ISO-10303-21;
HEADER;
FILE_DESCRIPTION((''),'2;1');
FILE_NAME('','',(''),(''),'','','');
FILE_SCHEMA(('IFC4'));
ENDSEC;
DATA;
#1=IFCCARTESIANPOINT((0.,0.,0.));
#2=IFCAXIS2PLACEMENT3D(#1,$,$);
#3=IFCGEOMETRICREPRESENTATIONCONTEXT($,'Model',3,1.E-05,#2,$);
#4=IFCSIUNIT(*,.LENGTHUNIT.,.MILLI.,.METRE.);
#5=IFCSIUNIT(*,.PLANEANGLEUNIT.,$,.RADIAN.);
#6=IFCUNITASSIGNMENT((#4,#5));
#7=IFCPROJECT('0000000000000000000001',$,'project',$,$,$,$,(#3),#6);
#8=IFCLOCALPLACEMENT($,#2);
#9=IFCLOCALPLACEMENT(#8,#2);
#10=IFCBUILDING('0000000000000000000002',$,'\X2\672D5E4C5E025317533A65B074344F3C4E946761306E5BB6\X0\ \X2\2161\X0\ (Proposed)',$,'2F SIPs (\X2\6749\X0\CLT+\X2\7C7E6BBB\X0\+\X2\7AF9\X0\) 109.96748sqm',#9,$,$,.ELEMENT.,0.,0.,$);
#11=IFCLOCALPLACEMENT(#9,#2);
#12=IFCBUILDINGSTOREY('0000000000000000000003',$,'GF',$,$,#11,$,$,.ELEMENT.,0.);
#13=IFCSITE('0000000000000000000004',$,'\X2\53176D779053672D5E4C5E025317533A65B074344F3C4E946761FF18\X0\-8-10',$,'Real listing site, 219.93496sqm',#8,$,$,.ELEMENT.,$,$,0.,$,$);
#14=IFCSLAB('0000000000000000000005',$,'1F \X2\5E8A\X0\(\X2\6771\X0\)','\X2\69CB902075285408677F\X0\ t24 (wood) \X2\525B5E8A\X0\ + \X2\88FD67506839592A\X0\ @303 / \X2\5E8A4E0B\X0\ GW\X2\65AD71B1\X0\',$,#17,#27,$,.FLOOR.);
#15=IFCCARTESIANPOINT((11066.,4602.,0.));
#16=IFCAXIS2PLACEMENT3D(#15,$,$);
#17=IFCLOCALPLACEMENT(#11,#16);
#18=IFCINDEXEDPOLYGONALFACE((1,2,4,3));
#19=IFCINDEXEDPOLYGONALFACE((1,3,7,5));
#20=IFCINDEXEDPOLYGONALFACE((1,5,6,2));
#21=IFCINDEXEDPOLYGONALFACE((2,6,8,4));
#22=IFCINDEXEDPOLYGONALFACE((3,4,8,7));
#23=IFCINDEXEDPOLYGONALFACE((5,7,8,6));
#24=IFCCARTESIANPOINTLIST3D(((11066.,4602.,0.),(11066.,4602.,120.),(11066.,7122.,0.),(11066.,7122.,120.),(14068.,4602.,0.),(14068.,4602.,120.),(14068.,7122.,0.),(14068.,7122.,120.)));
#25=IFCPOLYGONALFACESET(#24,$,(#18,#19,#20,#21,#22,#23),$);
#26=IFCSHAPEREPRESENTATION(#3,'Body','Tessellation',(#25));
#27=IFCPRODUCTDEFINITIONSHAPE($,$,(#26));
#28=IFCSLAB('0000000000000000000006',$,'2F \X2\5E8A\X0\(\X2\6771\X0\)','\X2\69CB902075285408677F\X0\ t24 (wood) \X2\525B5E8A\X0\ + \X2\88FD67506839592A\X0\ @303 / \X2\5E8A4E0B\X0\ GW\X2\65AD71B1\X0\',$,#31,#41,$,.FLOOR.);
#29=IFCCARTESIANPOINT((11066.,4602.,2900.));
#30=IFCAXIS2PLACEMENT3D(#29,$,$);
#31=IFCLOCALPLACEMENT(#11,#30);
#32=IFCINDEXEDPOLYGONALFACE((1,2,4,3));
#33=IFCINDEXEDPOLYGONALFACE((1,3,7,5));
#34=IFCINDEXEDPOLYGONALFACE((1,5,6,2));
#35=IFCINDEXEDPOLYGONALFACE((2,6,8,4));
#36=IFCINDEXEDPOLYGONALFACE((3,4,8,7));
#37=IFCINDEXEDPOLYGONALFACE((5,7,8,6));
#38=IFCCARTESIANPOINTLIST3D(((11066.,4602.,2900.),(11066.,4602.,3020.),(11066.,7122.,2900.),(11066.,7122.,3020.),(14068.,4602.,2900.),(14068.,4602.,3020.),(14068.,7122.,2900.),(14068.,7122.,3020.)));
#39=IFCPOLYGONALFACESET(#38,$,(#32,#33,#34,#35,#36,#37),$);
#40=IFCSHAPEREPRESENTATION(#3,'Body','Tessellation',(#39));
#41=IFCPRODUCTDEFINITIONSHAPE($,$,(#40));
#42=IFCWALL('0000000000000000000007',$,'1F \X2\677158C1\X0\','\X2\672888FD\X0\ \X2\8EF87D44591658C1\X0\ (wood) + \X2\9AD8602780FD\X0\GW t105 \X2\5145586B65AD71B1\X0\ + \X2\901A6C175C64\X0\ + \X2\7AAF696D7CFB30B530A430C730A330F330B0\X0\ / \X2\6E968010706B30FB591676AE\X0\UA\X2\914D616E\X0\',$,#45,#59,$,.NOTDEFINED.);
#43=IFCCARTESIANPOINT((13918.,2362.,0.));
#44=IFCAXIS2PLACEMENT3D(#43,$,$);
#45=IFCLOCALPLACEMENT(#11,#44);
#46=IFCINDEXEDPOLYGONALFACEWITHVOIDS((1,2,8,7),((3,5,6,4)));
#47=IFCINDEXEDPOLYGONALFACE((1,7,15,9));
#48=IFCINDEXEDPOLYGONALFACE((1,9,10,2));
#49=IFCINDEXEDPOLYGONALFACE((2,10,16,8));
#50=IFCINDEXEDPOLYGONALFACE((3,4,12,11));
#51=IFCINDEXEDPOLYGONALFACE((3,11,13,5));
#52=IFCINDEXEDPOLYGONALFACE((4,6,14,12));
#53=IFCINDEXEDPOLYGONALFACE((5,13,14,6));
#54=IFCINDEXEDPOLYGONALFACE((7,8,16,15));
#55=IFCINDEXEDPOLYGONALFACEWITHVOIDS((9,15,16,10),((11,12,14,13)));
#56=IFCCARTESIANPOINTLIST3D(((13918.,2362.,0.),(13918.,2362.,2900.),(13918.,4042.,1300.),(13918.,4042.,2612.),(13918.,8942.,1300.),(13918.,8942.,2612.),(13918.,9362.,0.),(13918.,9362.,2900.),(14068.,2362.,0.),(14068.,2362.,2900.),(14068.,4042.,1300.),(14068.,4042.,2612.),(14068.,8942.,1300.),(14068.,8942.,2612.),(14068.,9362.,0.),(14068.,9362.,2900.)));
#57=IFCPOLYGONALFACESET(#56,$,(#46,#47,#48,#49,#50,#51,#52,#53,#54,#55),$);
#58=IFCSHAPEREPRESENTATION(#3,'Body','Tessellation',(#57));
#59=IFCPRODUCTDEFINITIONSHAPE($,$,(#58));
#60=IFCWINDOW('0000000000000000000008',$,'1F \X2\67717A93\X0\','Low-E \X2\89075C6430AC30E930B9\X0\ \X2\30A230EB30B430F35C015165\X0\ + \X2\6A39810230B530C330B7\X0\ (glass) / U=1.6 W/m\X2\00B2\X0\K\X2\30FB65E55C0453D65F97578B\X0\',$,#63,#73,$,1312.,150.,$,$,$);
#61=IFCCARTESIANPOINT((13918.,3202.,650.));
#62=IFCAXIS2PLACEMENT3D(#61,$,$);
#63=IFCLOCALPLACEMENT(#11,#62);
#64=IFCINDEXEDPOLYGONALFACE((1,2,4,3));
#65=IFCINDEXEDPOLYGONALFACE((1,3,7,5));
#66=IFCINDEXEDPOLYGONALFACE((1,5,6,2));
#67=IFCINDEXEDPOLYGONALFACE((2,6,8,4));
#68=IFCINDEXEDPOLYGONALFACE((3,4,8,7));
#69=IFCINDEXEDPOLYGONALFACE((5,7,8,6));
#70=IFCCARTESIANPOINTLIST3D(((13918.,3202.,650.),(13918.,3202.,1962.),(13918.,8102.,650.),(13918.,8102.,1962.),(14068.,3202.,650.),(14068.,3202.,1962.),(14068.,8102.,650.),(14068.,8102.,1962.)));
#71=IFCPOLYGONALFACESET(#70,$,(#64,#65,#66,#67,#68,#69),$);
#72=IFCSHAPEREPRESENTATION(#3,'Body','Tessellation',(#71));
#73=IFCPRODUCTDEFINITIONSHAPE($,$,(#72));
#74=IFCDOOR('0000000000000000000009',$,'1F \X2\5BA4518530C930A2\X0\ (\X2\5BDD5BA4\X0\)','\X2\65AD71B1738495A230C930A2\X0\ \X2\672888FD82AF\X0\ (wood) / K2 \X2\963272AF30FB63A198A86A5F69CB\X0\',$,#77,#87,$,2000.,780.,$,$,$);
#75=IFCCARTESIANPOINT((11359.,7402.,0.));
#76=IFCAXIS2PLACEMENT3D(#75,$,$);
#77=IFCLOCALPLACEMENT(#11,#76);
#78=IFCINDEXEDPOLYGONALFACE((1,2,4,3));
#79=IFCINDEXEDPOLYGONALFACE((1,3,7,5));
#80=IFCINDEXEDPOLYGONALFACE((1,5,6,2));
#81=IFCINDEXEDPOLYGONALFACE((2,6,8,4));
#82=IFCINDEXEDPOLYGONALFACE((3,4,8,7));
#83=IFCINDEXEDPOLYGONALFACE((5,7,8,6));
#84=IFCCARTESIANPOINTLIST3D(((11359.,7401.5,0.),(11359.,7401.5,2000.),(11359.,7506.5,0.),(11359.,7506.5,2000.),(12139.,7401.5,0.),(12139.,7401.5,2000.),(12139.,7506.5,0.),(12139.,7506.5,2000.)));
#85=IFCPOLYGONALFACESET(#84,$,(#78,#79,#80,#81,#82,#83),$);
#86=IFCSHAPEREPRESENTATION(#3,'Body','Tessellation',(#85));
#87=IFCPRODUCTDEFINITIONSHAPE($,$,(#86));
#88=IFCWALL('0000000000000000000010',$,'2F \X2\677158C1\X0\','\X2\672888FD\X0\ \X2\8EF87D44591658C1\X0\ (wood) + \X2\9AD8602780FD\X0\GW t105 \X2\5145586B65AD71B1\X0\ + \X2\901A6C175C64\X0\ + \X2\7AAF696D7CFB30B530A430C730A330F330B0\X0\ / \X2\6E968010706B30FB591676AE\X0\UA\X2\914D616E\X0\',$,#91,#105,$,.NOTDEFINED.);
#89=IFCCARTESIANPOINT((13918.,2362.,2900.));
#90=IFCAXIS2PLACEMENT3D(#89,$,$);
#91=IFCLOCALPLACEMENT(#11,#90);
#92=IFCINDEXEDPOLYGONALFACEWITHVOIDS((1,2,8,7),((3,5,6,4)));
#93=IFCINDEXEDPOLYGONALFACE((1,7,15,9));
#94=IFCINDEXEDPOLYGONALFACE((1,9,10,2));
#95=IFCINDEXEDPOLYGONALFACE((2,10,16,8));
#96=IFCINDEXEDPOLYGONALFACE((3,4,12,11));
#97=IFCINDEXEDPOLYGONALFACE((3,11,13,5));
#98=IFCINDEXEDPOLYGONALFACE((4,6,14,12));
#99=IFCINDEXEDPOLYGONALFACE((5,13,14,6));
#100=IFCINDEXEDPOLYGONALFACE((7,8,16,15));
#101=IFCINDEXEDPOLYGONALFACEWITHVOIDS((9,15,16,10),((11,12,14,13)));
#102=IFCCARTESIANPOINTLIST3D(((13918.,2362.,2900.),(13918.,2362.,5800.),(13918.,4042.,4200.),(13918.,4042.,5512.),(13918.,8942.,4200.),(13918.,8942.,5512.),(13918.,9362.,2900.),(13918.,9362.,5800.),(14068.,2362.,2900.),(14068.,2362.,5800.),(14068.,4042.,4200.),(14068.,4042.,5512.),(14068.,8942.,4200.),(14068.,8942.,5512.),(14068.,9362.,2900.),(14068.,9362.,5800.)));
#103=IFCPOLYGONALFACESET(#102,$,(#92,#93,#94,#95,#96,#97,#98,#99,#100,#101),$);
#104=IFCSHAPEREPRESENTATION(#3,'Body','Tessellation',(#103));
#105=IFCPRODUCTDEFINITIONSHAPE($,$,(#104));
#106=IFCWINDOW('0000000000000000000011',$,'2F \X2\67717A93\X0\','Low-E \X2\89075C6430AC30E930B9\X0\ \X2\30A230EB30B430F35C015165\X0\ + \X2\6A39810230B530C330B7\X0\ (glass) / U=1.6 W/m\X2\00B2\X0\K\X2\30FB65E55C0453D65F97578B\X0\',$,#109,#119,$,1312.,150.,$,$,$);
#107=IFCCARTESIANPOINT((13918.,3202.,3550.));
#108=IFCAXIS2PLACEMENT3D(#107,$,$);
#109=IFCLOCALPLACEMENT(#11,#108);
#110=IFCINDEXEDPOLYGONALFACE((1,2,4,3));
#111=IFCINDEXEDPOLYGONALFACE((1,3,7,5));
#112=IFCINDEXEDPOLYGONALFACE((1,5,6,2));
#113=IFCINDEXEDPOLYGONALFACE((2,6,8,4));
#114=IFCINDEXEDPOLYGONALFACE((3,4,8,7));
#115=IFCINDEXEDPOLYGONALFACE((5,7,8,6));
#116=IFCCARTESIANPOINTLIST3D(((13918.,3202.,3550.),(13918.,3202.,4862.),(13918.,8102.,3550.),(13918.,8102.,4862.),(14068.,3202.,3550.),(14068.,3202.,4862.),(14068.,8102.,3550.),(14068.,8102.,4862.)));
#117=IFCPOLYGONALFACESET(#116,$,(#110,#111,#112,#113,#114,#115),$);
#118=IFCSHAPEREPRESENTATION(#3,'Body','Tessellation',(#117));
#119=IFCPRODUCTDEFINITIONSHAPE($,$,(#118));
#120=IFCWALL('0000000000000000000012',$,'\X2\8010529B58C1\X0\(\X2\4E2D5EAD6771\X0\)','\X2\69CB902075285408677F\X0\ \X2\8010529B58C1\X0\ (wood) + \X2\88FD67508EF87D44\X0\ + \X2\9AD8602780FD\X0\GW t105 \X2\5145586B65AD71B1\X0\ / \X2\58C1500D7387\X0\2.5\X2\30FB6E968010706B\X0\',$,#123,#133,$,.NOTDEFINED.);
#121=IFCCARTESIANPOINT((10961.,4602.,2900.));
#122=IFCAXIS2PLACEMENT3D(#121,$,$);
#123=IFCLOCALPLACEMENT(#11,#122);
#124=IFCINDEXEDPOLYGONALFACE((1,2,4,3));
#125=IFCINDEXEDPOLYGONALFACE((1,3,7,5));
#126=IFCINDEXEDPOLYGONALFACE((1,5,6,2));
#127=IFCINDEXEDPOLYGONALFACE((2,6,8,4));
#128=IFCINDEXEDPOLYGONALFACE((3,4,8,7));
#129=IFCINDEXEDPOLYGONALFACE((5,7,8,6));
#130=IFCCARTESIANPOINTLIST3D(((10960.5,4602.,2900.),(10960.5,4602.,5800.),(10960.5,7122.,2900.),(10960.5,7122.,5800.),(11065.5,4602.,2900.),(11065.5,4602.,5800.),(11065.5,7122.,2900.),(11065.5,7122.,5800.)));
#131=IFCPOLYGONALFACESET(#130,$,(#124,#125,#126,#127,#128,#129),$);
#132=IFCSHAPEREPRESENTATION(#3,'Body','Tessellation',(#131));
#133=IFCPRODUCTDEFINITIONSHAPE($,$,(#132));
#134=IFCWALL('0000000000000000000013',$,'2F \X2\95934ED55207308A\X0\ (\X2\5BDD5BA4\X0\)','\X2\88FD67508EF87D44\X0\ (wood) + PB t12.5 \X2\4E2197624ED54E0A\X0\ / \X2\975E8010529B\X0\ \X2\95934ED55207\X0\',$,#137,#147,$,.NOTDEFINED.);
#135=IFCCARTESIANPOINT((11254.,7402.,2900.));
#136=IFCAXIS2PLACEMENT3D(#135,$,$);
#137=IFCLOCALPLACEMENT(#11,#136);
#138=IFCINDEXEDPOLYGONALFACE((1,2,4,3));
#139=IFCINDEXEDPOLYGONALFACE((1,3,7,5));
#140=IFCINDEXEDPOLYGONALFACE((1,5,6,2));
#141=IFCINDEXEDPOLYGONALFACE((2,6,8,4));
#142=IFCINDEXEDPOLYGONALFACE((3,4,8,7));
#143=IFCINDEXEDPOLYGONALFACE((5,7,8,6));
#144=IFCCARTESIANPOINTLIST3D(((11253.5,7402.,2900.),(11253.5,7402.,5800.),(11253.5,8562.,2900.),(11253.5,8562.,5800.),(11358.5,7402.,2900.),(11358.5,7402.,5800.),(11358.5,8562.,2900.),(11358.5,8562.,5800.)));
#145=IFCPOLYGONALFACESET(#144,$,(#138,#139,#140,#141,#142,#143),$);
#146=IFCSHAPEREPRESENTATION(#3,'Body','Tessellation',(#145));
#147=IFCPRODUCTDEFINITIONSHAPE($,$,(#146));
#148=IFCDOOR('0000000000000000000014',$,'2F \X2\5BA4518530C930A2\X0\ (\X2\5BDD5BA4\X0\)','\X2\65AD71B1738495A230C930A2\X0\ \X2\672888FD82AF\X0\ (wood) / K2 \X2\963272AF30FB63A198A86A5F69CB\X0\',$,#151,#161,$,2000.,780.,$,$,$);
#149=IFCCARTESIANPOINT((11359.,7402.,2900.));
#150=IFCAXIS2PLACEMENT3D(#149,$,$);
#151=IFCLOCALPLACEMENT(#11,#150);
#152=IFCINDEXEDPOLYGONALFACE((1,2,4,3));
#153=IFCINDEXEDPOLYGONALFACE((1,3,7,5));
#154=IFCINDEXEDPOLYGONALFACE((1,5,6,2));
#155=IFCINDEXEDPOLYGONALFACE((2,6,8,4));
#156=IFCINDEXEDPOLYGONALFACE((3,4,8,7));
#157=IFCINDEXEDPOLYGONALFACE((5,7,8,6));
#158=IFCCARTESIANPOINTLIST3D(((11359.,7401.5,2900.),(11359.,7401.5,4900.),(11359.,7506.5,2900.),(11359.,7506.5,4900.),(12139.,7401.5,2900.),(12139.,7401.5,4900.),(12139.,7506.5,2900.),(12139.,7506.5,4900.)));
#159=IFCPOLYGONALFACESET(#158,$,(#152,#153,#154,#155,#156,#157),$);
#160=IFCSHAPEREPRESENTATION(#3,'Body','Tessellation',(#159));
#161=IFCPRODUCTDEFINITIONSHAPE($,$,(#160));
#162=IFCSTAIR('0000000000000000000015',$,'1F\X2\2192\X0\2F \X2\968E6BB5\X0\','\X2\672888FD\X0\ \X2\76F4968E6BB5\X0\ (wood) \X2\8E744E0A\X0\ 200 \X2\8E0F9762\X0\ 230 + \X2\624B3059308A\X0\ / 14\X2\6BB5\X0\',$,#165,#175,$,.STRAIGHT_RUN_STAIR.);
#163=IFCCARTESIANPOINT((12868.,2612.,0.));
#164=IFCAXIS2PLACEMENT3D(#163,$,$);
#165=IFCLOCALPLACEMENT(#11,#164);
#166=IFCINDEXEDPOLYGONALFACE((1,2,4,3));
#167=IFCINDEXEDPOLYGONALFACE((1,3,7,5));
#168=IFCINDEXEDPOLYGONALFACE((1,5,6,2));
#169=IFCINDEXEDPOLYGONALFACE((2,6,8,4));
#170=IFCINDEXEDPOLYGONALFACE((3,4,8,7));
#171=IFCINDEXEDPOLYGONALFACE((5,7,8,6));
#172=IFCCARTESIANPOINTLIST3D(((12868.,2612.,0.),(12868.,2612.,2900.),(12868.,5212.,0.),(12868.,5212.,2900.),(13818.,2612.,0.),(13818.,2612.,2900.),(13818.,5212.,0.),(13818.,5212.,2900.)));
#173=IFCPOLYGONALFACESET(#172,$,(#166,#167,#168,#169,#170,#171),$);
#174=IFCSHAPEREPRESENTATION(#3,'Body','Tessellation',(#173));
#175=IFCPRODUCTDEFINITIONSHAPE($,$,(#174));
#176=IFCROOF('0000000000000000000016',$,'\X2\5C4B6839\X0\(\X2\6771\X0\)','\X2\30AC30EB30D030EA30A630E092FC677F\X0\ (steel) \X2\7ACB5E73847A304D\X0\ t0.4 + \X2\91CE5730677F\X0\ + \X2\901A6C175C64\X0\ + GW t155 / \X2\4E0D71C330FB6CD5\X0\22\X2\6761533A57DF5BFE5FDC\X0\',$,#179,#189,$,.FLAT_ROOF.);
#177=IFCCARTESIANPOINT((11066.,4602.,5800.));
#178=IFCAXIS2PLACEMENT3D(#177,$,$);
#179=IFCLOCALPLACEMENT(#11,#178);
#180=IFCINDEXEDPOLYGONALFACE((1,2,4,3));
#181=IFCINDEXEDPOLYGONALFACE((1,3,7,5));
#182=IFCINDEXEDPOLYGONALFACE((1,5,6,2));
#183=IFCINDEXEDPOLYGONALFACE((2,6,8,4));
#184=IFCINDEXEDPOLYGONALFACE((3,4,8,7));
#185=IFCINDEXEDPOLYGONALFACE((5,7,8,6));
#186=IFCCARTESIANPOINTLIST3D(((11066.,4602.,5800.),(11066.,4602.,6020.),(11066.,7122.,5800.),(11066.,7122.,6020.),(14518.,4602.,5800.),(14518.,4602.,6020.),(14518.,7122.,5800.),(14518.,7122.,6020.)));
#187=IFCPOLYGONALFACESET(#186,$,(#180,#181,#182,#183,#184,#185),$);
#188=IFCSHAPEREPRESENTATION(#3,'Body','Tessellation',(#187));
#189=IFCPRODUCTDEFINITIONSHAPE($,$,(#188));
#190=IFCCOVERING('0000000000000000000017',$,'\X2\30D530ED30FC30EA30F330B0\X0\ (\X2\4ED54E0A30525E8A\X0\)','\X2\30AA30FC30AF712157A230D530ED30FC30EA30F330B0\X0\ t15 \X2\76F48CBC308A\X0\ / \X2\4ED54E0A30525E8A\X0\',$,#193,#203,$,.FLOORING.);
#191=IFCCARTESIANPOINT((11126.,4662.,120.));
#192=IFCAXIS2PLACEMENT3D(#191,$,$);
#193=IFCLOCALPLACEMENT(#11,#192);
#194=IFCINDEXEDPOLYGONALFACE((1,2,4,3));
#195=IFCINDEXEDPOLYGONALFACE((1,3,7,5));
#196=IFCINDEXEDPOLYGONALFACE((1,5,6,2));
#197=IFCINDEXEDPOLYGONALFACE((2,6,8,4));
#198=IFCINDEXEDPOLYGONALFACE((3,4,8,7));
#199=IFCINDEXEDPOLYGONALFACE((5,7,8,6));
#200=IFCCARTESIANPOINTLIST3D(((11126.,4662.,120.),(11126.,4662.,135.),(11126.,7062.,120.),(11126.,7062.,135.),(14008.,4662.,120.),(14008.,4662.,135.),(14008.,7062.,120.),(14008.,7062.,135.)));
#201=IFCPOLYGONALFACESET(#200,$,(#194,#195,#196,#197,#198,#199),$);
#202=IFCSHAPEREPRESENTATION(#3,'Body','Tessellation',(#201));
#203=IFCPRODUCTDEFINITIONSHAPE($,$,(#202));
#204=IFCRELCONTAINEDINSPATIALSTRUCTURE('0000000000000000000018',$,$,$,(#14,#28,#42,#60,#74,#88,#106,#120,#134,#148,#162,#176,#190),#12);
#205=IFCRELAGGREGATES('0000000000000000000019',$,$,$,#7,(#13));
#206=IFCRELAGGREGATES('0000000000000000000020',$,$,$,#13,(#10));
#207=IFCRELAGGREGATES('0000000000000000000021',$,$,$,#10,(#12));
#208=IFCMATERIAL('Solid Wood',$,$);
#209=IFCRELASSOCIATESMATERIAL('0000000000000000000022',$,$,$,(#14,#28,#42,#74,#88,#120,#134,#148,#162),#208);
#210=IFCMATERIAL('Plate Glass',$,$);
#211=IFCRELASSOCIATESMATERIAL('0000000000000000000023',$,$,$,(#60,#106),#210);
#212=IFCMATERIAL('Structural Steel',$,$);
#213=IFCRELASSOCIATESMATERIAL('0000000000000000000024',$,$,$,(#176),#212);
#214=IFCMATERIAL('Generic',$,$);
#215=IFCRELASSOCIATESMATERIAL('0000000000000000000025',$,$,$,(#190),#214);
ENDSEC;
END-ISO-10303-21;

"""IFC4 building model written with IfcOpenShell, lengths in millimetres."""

from ifc_helpers import new_model, si_unit, frame, frame_2d, origin, place, context, project, spatial, rectangle, extrude, material, element, fill, save


model = new_model("IFC4")

# Units and contexts
model_context = context("Model", 3, precision=1e-05, world=origin())
ifc_project = project(units=[si_unit("LENGTHUNIT", "METRE", prefix="MILLI"), si_unit("PLANEANGLEUNIT", "RADIAN")], contexts=[model_context])

# Site, building, storey
site_placement = place(None, origin())
site = spatial("IfcSite", under=ifc_project, at=site_placement, Name="北海道札幌市北区新琴似五条８-8-10", ObjectType="Real listing site, 219.93496sqm", CompositionType="ELEMENT", RefElevation=0.0)
building_placement = place(site_placement, origin())
building = spatial("IfcBuilding", under=site, at=building_placement, Name="札幌市北区新琴似五条の家 Ⅱ (Proposed)", ObjectType="2F SIPs (杉CLT+籾殻+竹) 109.96748sqm", CompositionType="ELEMENT", ElevationOfRefHeight=0.0, ElevationOfTerrain=0.0)
storey_placement = place(building_placement, origin())
storey = spatial("IfcBuildingStorey", under=building, at=storey_placement, Name="GF", CompositionType="ELEMENT", Elevation=0.0)

# Slabs
ifc_material_1 = material(Name="Solid Wood")
slab_1_placement = place(storey_placement, frame((11066.0, 4602.0, 0.0)))
element("IfcSlab", 1, at=slab_1_placement, inside=storey, material=ifc_material_1, Name="1F 床(東)", Description="構造用合板 t24 (wood) 剛床 + 製材根太 @303 / 床下 GW断熱", PredefinedType="FLOOR", context=model_context, shape_type="SweptSolid", body=[
    extrude(rectangle(XDim=3002.0, YDim=2520.0, at=frame_2d((1501.0, 1260.0))), frame((11066.0, 4602.0, 0.0)), (0.0, 0.0, 1.0), 120.0),
])
slab_2_placement = place(storey_placement, frame((11066.0, 4602.0, 2900.0)))
element("IfcSlab", 2, at=slab_2_placement, inside=storey, material=ifc_material_1, Name="2F 床(東)", Description="構造用合板 t24 (wood) 剛床 + 製材根太 @303 / 床下 GW断熱", PredefinedType="FLOOR", context=model_context, shape_type="SweptSolid", body=[
    extrude(rectangle(XDim=3002.0, YDim=2520.0, at=frame_2d((1501.0, 1260.0))), frame((11066.0, 4602.0, 2900.0)), (0.0, 0.0, 1.0), 120.0),
])

# Wall, opening, window
wall_1_placement = place(storey_placement, frame((13918.0, 2362.0, 0.0)))
wall_1 = element("IfcWall", 3, at=wall_1_placement, inside=storey, material=ifc_material_1, Name="1F 東壁", Description="木製 軸組外壁 (wood) + 高性能GW t105 充填断熱 + 通気層 + 窯業系サイディング / 準耐火・外皮UA配慮", PredefinedType="NOTDEFINED", context=model_context, shape_type="SweptSolid", body=[
    extrude(rectangle(XDim=150.0, YDim=7000.0, at=frame_2d((75.0, 3500.0))), frame((13918.0, 2362.0, 0.0)), (0.0, 0.0, 1.0), 2900.0),
])
opening_1_placement = place(storey_placement, frame((13918.0, 3202.0, 650.0)))
opening_1 = element("IfcOpeningElement", 4, at=opening_1_placement, cuts=wall_1, PredefinedType="NOTDEFINED", context=model_context, shape_type="SweptSolid", body=[
    extrude(rectangle(XDim=150.0, YDim=4900.0, at=frame_2d((75.0, 2450.0))), frame((13918.0, 3202.0, 650.0)), (0.0, 0.0, 1.0), 1312.0),
])
ifc_material_2 = material(Name="Plate Glass")
window_1_placement = place(storey_placement, frame((13918.0, 3202.0, 650.0)))
window_1 = element("IfcWindow", 5, at=window_1_placement, inside=storey, material=ifc_material_2, Name="1F 東窓", Description="Low-E 複層ガラス アルゴン封入 + 樹脂サッシ (glass) / U=1.6 W/m²K・日射取得型", OverallHeight=1312.0, OverallWidth=150.0, context=model_context, shape_type="SweptSolid", body=[
    extrude(rectangle(XDim=150.0, YDim=4900.0, at=frame_2d((75.0, 2450.0))), frame((13918.0, 3202.0, 650.0)), (0.0, 0.0, 1.0), 1312.0),
])
fill(opening_1, window_1)

# Door
door_1_placement = place(storey_placement, frame((11359.0, 7402.0, 0.0)))
element("IfcDoor", 6, at=door_1_placement, inside=storey, material=ifc_material_1, Name="1F 室内ドア (寝室)", Description="断熱玄関ドア 木製芯 (wood) / K2 防犯・採風機構", OverallHeight=2000.0, OverallWidth=780.0, context=model_context, shape_type="SweptSolid", body=[
    extrude(rectangle(XDim=780.0, YDim=105.0, at=frame_2d((390.0, 52.0))), frame((11359.0, 7402.0, 0.0)), (0.0, 0.0, 1.0), 2000.0),
])

# Wall, opening, window
wall_2_placement = place(storey_placement, frame((13918.0, 2362.0, 2900.0)))
wall_2 = element("IfcWall", 7, at=wall_2_placement, inside=storey, material=ifc_material_1, Name="2F 東壁", Description="木製 軸組外壁 (wood) + 高性能GW t105 充填断熱 + 通気層 + 窯業系サイディング / 準耐火・外皮UA配慮", PredefinedType="NOTDEFINED", context=model_context, shape_type="SweptSolid", body=[
    extrude(rectangle(XDim=150.0, YDim=7000.0, at=frame_2d((75.0, 3500.0))), frame((13918.0, 2362.0, 2900.0)), (0.0, 0.0, 1.0), 2900.0),
])
opening_2_placement = place(storey_placement, frame((13918.0, 3202.0, 3550.0)))
opening_2 = element("IfcOpeningElement", 8, at=opening_2_placement, cuts=wall_2, PredefinedType="NOTDEFINED", context=model_context, shape_type="SweptSolid", body=[
    extrude(rectangle(XDim=150.0, YDim=4900.0, at=frame_2d((75.0, 2450.0))), frame((13918.0, 3202.0, 3550.0)), (0.0, 0.0, 1.0), 1312.0),
])
window_2_placement = place(storey_placement, frame((13918.0, 3202.0, 3550.0)))
window_2 = element("IfcWindow", 9, at=window_2_placement, inside=storey, material=ifc_material_2, Name="2F 東窓", Description="Low-E 複層ガラス アルゴン封入 + 樹脂サッシ (glass) / U=1.6 W/m²K・日射取得型", OverallHeight=1312.0, OverallWidth=150.0, context=model_context, shape_type="SweptSolid", body=[
    extrude(rectangle(XDim=150.0, YDim=4900.0, at=frame_2d((75.0, 2450.0))), frame((13918.0, 3202.0, 3550.0)), (0.0, 0.0, 1.0), 1312.0),
])
fill(opening_2, window_2)

# Walls
wall_3_placement = place(storey_placement, frame((10961.0, 4602.0, 2900.0)))
element("IfcWall", 10, at=wall_3_placement, inside=storey, material=ifc_material_1, Name="耐力壁(中庭東)", Description="構造用合板 耐力壁 (wood) + 製材軸組 + 高性能GW t105 充填断熱 / 壁倍率2.5・準耐火", PredefinedType="NOTDEFINED", context=model_context, shape_type="SweptSolid", body=[
    extrude(rectangle(XDim=105.0, YDim=2520.0, at=frame_2d((52.0, 1260.0))), frame((10961.0, 4602.0, 2900.0)), (0.0, 0.0, 1.0), 2900.0),
])
wall_4_placement = place(storey_placement, frame((11254.0, 7402.0, 2900.0)))
element("IfcWall", 11, at=wall_4_placement, inside=storey, material=ifc_material_1, Name="2F 間仕切り (寝室)", Description="製材軸組 (wood) + PB t12.5 両面仕上 / 非耐力 間仕切", PredefinedType="NOTDEFINED", context=model_context, shape_type="SweptSolid", body=[
    extrude(rectangle(XDim=105.0, YDim=1160.0, at=frame_2d((52.0, 580.0))), frame((11254.0, 7402.0, 2900.0)), (0.0, 0.0, 1.0), 2900.0),
])

# Door
door_2_placement = place(storey_placement, frame((11359.0, 7402.0, 2900.0)))
element("IfcDoor", 12, at=door_2_placement, inside=storey, material=ifc_material_1, Name="2F 室内ドア (寝室)", Description="断熱玄関ドア 木製芯 (wood) / K2 防犯・採風機構", OverallHeight=2000.0, OverallWidth=780.0, context=model_context, shape_type="SweptSolid", body=[
    extrude(rectangle(XDim=780.0, YDim=105.0, at=frame_2d((390.0, 52.0))), frame((11359.0, 7402.0, 2900.0)), (0.0, 0.0, 1.0), 2000.0),
])

# Stair
stair_placement = place(storey_placement, frame((12868.0, 2612.0, 0.0)))
element("IfcStair", 13, at=stair_placement, inside=storey, material=ifc_material_1, Name="1F→2F 階段", Description="木製 直階段 (wood) 蹴上 200 踏面 230 + 手すり / 14段", PredefinedType="STRAIGHT_RUN_STAIR", context=model_context, shape_type="SweptSolid", body=[
    extrude(rectangle(XDim=950.0, YDim=2600.0, at=frame_2d((475.0, 1300.0))), frame((12868.0, 2612.0, 0.0)), (0.0, 0.0, 1.0), 2900.0),
])

# Roof
ifc_material_3 = material(Name="Structural Steel")
for number, where, name in (
    (14, (11066.0, 4602.0, 5800.0), "屋根(東)"),
):
    element("IfcRoof", number, at=place(storey_placement, frame(where)), inside=storey, material=ifc_material_3, Name=name, Description="ガルバリウム鋼板 (steel) 立平葺き t0.4 + 野地板 + 通気層 + GW t155 / 不燃・法22条区域対応", PredefinedType="FLAT_ROOF", context=model_context, shape_type="SweptSolid", body=[
        extrude(rectangle(XDim=3452.0, YDim=2520.0, at=frame_2d((1726.0, 1260.0))), frame((11066.0, 4602.0, 5800.0)), (0.0, 0.0, 1.0), 220.0),
    ])

# Covering
ifc_material_4 = material(Name="Generic")
covering_1_placement = place(storey_placement, frame((11126.0, 4662.0, 120.0)))
element("IfcCovering", 15, at=covering_1_placement, inside=storey, material=ifc_material_4, Name="フローリング (仕上げ床)", Description="オーク無垢フローリング t15 直貼り / 仕上げ床", PredefinedType="FLOORING", context=model_context, shape_type="SweptSolid", body=[
    extrude(rectangle(XDim=2882.0, YDim=2400.0, at=frame_2d((1441.0, 1200.0))), frame((11126.0, 4662.0, 120.0)), (0.0, 0.0, 1.0), 15.0),
])

save(model, "model.ifc")
